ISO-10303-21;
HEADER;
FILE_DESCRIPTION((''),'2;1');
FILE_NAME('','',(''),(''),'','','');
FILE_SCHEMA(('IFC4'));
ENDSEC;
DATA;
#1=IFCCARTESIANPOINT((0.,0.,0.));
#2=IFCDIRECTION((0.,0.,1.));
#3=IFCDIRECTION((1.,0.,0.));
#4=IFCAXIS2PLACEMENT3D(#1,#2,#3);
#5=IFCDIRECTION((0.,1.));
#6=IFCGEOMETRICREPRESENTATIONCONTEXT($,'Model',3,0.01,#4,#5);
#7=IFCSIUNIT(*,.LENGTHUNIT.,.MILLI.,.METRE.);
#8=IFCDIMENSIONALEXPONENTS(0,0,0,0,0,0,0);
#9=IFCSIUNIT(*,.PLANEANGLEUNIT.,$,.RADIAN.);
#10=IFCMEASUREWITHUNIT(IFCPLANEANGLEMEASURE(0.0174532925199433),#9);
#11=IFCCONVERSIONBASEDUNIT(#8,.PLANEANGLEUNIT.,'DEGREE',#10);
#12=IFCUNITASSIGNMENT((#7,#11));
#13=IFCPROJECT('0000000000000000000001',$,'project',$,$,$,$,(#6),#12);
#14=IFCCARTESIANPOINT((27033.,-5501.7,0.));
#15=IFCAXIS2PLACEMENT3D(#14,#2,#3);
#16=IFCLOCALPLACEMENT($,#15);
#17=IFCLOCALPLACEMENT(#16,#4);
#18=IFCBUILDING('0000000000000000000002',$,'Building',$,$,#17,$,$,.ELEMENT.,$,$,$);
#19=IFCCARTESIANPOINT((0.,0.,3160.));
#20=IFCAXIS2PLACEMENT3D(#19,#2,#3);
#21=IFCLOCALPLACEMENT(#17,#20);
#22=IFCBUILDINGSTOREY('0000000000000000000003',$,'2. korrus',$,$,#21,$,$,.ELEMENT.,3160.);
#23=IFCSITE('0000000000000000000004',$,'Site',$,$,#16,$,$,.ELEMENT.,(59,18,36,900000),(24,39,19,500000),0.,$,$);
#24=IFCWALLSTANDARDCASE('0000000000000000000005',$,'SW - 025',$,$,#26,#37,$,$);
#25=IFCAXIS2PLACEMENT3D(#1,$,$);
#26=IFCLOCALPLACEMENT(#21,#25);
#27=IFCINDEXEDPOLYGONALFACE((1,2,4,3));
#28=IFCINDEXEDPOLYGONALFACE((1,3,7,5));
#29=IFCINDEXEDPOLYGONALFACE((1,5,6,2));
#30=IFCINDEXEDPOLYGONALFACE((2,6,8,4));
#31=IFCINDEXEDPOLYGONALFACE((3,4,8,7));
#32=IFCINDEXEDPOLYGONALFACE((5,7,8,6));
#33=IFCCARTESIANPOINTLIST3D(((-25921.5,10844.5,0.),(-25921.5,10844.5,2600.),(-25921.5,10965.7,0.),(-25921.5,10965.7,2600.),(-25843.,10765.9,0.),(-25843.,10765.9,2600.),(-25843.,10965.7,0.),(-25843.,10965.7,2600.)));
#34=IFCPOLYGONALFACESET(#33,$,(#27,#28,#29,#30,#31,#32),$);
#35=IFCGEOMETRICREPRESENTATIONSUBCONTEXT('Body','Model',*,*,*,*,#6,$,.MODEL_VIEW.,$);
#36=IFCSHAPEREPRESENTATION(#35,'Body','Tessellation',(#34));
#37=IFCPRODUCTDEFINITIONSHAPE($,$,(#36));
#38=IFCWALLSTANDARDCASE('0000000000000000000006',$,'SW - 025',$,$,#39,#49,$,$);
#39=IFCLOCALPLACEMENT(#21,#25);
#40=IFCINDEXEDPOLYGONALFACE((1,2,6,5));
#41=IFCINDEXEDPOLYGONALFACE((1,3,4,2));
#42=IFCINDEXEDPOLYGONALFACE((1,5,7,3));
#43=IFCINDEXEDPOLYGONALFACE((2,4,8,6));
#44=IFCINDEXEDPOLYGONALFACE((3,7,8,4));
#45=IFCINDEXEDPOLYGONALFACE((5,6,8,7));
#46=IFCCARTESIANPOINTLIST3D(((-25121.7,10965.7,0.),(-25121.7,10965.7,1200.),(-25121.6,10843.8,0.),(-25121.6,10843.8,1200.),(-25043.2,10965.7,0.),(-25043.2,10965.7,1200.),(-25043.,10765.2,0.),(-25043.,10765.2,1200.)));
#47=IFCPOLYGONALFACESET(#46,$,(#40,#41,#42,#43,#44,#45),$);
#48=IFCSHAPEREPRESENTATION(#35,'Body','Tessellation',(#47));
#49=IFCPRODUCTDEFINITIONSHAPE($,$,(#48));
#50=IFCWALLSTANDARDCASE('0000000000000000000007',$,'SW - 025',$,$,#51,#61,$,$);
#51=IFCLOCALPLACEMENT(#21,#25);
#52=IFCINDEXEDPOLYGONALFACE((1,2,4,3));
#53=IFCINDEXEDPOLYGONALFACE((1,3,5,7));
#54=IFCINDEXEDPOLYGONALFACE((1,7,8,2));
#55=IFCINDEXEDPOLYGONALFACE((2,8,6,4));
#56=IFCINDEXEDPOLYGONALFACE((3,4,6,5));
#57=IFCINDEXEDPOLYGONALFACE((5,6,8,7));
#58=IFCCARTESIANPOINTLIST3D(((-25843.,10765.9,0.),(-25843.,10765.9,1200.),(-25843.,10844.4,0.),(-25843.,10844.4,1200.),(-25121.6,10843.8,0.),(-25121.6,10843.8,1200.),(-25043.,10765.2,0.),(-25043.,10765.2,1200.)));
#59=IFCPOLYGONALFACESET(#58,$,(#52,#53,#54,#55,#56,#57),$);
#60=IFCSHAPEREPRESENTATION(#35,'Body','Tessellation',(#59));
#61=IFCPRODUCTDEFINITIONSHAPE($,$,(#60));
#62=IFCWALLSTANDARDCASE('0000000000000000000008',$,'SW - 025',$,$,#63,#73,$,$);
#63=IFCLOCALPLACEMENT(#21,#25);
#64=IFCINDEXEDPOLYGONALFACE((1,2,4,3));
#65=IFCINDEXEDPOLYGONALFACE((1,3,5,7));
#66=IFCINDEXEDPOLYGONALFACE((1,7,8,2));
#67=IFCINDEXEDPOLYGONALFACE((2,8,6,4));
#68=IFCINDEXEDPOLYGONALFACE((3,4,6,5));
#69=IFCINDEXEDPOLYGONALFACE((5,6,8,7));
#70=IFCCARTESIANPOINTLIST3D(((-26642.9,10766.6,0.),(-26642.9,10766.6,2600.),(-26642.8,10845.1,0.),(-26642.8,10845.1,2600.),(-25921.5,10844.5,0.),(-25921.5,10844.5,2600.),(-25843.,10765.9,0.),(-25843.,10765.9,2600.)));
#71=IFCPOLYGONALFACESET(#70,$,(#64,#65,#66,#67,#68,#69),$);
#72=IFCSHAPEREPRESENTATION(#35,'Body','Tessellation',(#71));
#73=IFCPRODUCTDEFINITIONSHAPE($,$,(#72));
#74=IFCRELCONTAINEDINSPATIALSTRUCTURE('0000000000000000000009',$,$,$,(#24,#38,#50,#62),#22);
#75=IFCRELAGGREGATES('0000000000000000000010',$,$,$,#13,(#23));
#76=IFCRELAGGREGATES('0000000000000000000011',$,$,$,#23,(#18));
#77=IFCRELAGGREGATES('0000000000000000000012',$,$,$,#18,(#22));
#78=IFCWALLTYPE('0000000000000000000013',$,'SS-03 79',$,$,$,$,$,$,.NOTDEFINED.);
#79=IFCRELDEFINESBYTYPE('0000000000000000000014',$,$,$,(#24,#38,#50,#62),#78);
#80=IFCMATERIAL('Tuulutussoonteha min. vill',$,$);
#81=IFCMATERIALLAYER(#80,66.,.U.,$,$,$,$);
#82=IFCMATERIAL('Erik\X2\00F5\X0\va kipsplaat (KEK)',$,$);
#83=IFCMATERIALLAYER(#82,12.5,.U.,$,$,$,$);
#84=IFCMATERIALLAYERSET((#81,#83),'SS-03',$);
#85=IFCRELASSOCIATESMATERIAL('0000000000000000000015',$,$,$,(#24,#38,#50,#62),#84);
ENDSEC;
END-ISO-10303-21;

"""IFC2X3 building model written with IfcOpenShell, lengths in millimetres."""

from ifc_helpers import new_model, entity, si_unit, converted_unit, direction, frame, origin_with_axes, place, context, subcontext, project, spatial, polyline, outline, extrude, material, layer, layer_set, layer_usage, type_object, element, save


model = new_model("IFC2X3")

# Units and contexts
model_context = context("Model", 3, precision=0.01, world=origin_with_axes(), true_north=direction((0.0, 1.0)))
body_context = subcontext(model_context, "Body", "Model", "MODEL_VIEW")
ifc_project = project(units=[si_unit("LENGTHUNIT", "METRE", prefix="MILLI"), converted_unit("PLANEANGLEUNIT", "DEGREE", entity("IfcPlaneAngleMeasure", 0.0174532925199433), si_unit("PLANEANGLEUNIT", "RADIAN"), dimensions=[0, 0, 0, 0, 0, 0, 0])], contexts=[model_context])

# Site, building, storey
site_placement = place(None, frame((27033.0, -5501.7, 0.0), z_axis=(0.0, 0.0, 1.0), x_axis=(1.0, 0.0, 0.0)))
site = spatial("IfcSite", under=ifc_project, at=site_placement, Name="Site", CompositionType="ELEMENT", RefLatitude=(59, 18, 36, 900000), RefLongitude=(24, 39, 19, 500000), RefElevation=0.0)
building_placement = place(site_placement, origin_with_axes())
building = spatial("IfcBuilding", under=site, at=building_placement, Name="Building", CompositionType="ELEMENT")
storey_placement = place(building_placement, frame((0.0, 0.0, 3160.0), z_axis=(0.0, 0.0, 1.0), x_axis=(1.0, 0.0, 0.0)))
storey = spatial("IfcBuildingStorey", under=building, at=storey_placement, Name="2. korrus", CompositionType="ELEMENT", Elevation=3160.0)

# Shared definitions
ifc_material_1 = material(Name="Erikõva kipsplaat (KEK)")
ifc_material_2 = material(Name="Tuulutussoonteha min. vill")

# Walls
ifc_layer_1 = layer(ifc_material_2, 66.0, ventilated="UNKNOWN")
ifc_layer_2 = layer(ifc_material_1, 12.5, ventilated="UNKNOWN")
ifc_layer_set_1 = layer_set([ifc_layer_1, ifc_layer_2], Name="SS-03")
wall_type_1 = type_object("IfcWallType", Name="SS-03 79", PredefinedType="NOTDEFINED")
ifc_layer_usage_1 = layer_usage(ifc_layer_set_1, "AXIS2", "NEGATIVE", 78.5)
wall_1_placement = place(storey_placement, frame((-25843.0, 10765.9, 0.0), z_axis=(0.0, 0.0, 1.0), x_axis=(0.0, 1.0, 0.0)))
element("IfcWallStandardCase", 1, at=wall_1_placement, inside=storey, type_object=wall_type_1, material=ifc_layer_usage_1, Name="SW - 025", context=body_context, shape_type="SweptSolid", body=[
    extrude(outline(polyline([(0.0, 0.0), (199.8, 0.0), (199.8, 78.5), (78.6, 78.5), (0.0, 0.0)])), origin_with_axes(), (0.0, 0.0, 1.0), 2600.0),
])
ifc_layer_usage_2 = layer_usage(ifc_layer_set_1, "AXIS2", "NEGATIVE", 78.5)
wall_2_placement = place(storey_placement, frame((-25043.0, 10765.2, 0.0), z_axis=(0.0, 0.0, 1.0), x_axis=(-0.000638, 1.0, 0.0)))
element("IfcWallStandardCase", 2, at=wall_2_placement, inside=storey, type_object=wall_type_1, material=ifc_layer_usage_2, Name="SW - 025", context=body_context, shape_type="SweptSolid", body=[
    extrude(outline(polyline([(0.0, 0.0), (200.5, 0.0), (200.5, 78.5), (78.6, 78.5), (0.0, 0.0)])), origin_with_axes(), (0.0, 0.0, 1.0), 1200.0),
])
ifc_layer_usage_3 = layer_usage(ifc_layer_set_1, "AXIS2", "NEGATIVE", 78.5)
wall_3_placement = place(storey_placement, frame((-25843.0, 10765.9, 0.0), z_axis=(0.0, 0.0, 1.0), x_axis=(1.0, -0.000859, 0.0)))
element("IfcWallStandardCase", 3, at=wall_3_placement, inside=storey, type_object=wall_type_1, material=ifc_layer_usage_3, Name="SW - 025", context=body_context, shape_type="SweptSolid", body=[
    extrude(outline(polyline([(0.0, 0.0), (800.0, 0.0), (721.4, 78.5), (-0.1, 78.5), (0.0, 0.0)])), origin_with_axes(), (0.0, 0.0, 1.0), 1200.0),
])
ifc_layer_usage_4 = layer_usage(ifc_layer_set_1, "AXIS2", "NEGATIVE", 78.5)
wall_4_placement = place(storey_placement, frame((-26642.9, 10766.6, 0.0), z_axis=(0.0, 0.0, 1.0), x_axis=(1.0, -0.000859, 0.0)))
element("IfcWallStandardCase", 4, at=wall_4_placement, inside=storey, type_object=wall_type_1, material=ifc_layer_usage_4, Name="SW - 025", context=body_context, shape_type="SweptSolid", body=[
    extrude(outline(polyline([(0.0, 0.0), (799.9, 0.0), (721.3, 78.5), (0.0, 78.5), (0.0, 0.0)])), origin_with_axes(), (0.0, 0.0, 1.0), 2600.0),
])

save(model, "model.ifc")
